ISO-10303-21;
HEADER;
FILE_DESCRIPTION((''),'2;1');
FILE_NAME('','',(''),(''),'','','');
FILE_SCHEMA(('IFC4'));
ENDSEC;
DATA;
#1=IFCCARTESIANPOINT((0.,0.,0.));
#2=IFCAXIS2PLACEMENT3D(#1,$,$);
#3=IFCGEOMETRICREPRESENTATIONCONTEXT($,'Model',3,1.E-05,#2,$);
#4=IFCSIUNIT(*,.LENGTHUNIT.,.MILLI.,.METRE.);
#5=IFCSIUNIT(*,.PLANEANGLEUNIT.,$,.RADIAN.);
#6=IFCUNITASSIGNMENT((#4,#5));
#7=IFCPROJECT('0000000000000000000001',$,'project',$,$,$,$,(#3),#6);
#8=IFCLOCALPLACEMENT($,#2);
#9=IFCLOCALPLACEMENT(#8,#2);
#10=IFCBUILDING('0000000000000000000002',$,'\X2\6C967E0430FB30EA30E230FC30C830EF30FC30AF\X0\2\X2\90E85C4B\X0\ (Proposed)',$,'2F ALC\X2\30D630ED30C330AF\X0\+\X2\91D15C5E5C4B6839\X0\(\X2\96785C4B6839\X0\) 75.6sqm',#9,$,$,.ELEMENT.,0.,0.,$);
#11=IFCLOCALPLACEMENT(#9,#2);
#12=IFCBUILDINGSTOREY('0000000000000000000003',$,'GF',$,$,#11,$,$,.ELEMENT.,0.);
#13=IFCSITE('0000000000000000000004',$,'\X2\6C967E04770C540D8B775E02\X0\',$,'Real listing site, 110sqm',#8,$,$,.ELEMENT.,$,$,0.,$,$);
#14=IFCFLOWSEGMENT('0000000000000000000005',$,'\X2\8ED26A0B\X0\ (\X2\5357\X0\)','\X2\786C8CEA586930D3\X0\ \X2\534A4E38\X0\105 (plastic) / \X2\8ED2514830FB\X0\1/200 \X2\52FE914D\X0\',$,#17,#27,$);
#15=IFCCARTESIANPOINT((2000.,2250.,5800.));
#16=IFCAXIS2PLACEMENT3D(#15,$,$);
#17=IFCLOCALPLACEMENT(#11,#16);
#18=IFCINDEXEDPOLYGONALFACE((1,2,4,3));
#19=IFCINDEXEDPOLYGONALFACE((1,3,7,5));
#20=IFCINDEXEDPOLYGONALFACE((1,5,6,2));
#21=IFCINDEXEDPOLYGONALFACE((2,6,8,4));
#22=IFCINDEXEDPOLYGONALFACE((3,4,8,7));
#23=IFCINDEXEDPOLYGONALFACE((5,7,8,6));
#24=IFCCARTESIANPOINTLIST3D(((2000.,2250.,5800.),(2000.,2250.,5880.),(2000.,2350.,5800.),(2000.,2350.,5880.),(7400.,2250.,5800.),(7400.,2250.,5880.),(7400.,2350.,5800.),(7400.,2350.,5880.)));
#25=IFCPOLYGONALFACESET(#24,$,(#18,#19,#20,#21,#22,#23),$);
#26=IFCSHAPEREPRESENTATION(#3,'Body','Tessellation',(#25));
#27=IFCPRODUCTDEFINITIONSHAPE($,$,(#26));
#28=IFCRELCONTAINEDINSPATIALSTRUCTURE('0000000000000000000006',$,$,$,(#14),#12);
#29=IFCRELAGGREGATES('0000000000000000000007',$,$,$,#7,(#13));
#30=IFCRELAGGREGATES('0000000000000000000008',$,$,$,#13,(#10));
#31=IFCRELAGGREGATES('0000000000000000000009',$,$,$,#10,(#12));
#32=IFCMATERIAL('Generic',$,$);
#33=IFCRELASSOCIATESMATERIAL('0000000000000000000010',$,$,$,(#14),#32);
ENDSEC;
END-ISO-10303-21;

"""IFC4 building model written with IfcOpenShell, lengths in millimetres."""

from ifc_helpers import new_model, si_unit, frame, frame_2d, origin, place, context, project, spatial, rectangle, extrude, material, element, save


model = new_model("IFC4")

# Units and contexts
model_context = context("Model", 3, precision=1e-05, world=origin())
ifc_project = project(units=[si_unit("LENGTHUNIT", "METRE", prefix="MILLI"), si_unit("PLANEANGLEUNIT", "RADIAN")], contexts=[model_context])

# Site, building, storey
site_placement = place(None, origin())
site = spatial("IfcSite", under=ifc_project, at=site_placement, Name="沖縄県名護市", ObjectType="Real listing site, 110sqm", CompositionType="ELEMENT", RefElevation=0.0)
building_placement = place(site_placement, origin())
building = spatial("IfcBuilding", under=site, at=building_placement, Name="沖縄・リモートワーク2部屋 (Proposed)", ObjectType="2F ALCブロック+金属屋根(陸屋根) 75.6sqm", CompositionType="ELEMENT", ElevationOfRefHeight=0.0, ElevationOfTerrain=0.0)
storey_placement = place(building_placement, origin())
storey = spatial("IfcBuildingStorey", under=building, at=storey_placement, Name="GF", CompositionType="ELEMENT", Elevation=0.0)

# Flow segment
ifc_material_1 = material(Name="Generic")
flow_segment_placement = place(storey_placement, frame((2000.0, 2250.0, 5800.0)))
element("IfcFlowSegment", 1, at=flow_segment_placement, inside=storey, material=ifc_material_1, Name="軒樋 (南)", Description="硬質塩ビ 半丸105 (plastic) / 軒先・1/200 勾配", context=model_context, shape_type="SweptSolid", body=[
    extrude(rectangle(XDim=5400.0, YDim=100.0, at=frame_2d((2700.0, 50.0))), frame((2000.0, 2250.0, 5800.0)), (0.0, 0.0, 1.0), 80.0),
])

save(model, "model.ifc")
